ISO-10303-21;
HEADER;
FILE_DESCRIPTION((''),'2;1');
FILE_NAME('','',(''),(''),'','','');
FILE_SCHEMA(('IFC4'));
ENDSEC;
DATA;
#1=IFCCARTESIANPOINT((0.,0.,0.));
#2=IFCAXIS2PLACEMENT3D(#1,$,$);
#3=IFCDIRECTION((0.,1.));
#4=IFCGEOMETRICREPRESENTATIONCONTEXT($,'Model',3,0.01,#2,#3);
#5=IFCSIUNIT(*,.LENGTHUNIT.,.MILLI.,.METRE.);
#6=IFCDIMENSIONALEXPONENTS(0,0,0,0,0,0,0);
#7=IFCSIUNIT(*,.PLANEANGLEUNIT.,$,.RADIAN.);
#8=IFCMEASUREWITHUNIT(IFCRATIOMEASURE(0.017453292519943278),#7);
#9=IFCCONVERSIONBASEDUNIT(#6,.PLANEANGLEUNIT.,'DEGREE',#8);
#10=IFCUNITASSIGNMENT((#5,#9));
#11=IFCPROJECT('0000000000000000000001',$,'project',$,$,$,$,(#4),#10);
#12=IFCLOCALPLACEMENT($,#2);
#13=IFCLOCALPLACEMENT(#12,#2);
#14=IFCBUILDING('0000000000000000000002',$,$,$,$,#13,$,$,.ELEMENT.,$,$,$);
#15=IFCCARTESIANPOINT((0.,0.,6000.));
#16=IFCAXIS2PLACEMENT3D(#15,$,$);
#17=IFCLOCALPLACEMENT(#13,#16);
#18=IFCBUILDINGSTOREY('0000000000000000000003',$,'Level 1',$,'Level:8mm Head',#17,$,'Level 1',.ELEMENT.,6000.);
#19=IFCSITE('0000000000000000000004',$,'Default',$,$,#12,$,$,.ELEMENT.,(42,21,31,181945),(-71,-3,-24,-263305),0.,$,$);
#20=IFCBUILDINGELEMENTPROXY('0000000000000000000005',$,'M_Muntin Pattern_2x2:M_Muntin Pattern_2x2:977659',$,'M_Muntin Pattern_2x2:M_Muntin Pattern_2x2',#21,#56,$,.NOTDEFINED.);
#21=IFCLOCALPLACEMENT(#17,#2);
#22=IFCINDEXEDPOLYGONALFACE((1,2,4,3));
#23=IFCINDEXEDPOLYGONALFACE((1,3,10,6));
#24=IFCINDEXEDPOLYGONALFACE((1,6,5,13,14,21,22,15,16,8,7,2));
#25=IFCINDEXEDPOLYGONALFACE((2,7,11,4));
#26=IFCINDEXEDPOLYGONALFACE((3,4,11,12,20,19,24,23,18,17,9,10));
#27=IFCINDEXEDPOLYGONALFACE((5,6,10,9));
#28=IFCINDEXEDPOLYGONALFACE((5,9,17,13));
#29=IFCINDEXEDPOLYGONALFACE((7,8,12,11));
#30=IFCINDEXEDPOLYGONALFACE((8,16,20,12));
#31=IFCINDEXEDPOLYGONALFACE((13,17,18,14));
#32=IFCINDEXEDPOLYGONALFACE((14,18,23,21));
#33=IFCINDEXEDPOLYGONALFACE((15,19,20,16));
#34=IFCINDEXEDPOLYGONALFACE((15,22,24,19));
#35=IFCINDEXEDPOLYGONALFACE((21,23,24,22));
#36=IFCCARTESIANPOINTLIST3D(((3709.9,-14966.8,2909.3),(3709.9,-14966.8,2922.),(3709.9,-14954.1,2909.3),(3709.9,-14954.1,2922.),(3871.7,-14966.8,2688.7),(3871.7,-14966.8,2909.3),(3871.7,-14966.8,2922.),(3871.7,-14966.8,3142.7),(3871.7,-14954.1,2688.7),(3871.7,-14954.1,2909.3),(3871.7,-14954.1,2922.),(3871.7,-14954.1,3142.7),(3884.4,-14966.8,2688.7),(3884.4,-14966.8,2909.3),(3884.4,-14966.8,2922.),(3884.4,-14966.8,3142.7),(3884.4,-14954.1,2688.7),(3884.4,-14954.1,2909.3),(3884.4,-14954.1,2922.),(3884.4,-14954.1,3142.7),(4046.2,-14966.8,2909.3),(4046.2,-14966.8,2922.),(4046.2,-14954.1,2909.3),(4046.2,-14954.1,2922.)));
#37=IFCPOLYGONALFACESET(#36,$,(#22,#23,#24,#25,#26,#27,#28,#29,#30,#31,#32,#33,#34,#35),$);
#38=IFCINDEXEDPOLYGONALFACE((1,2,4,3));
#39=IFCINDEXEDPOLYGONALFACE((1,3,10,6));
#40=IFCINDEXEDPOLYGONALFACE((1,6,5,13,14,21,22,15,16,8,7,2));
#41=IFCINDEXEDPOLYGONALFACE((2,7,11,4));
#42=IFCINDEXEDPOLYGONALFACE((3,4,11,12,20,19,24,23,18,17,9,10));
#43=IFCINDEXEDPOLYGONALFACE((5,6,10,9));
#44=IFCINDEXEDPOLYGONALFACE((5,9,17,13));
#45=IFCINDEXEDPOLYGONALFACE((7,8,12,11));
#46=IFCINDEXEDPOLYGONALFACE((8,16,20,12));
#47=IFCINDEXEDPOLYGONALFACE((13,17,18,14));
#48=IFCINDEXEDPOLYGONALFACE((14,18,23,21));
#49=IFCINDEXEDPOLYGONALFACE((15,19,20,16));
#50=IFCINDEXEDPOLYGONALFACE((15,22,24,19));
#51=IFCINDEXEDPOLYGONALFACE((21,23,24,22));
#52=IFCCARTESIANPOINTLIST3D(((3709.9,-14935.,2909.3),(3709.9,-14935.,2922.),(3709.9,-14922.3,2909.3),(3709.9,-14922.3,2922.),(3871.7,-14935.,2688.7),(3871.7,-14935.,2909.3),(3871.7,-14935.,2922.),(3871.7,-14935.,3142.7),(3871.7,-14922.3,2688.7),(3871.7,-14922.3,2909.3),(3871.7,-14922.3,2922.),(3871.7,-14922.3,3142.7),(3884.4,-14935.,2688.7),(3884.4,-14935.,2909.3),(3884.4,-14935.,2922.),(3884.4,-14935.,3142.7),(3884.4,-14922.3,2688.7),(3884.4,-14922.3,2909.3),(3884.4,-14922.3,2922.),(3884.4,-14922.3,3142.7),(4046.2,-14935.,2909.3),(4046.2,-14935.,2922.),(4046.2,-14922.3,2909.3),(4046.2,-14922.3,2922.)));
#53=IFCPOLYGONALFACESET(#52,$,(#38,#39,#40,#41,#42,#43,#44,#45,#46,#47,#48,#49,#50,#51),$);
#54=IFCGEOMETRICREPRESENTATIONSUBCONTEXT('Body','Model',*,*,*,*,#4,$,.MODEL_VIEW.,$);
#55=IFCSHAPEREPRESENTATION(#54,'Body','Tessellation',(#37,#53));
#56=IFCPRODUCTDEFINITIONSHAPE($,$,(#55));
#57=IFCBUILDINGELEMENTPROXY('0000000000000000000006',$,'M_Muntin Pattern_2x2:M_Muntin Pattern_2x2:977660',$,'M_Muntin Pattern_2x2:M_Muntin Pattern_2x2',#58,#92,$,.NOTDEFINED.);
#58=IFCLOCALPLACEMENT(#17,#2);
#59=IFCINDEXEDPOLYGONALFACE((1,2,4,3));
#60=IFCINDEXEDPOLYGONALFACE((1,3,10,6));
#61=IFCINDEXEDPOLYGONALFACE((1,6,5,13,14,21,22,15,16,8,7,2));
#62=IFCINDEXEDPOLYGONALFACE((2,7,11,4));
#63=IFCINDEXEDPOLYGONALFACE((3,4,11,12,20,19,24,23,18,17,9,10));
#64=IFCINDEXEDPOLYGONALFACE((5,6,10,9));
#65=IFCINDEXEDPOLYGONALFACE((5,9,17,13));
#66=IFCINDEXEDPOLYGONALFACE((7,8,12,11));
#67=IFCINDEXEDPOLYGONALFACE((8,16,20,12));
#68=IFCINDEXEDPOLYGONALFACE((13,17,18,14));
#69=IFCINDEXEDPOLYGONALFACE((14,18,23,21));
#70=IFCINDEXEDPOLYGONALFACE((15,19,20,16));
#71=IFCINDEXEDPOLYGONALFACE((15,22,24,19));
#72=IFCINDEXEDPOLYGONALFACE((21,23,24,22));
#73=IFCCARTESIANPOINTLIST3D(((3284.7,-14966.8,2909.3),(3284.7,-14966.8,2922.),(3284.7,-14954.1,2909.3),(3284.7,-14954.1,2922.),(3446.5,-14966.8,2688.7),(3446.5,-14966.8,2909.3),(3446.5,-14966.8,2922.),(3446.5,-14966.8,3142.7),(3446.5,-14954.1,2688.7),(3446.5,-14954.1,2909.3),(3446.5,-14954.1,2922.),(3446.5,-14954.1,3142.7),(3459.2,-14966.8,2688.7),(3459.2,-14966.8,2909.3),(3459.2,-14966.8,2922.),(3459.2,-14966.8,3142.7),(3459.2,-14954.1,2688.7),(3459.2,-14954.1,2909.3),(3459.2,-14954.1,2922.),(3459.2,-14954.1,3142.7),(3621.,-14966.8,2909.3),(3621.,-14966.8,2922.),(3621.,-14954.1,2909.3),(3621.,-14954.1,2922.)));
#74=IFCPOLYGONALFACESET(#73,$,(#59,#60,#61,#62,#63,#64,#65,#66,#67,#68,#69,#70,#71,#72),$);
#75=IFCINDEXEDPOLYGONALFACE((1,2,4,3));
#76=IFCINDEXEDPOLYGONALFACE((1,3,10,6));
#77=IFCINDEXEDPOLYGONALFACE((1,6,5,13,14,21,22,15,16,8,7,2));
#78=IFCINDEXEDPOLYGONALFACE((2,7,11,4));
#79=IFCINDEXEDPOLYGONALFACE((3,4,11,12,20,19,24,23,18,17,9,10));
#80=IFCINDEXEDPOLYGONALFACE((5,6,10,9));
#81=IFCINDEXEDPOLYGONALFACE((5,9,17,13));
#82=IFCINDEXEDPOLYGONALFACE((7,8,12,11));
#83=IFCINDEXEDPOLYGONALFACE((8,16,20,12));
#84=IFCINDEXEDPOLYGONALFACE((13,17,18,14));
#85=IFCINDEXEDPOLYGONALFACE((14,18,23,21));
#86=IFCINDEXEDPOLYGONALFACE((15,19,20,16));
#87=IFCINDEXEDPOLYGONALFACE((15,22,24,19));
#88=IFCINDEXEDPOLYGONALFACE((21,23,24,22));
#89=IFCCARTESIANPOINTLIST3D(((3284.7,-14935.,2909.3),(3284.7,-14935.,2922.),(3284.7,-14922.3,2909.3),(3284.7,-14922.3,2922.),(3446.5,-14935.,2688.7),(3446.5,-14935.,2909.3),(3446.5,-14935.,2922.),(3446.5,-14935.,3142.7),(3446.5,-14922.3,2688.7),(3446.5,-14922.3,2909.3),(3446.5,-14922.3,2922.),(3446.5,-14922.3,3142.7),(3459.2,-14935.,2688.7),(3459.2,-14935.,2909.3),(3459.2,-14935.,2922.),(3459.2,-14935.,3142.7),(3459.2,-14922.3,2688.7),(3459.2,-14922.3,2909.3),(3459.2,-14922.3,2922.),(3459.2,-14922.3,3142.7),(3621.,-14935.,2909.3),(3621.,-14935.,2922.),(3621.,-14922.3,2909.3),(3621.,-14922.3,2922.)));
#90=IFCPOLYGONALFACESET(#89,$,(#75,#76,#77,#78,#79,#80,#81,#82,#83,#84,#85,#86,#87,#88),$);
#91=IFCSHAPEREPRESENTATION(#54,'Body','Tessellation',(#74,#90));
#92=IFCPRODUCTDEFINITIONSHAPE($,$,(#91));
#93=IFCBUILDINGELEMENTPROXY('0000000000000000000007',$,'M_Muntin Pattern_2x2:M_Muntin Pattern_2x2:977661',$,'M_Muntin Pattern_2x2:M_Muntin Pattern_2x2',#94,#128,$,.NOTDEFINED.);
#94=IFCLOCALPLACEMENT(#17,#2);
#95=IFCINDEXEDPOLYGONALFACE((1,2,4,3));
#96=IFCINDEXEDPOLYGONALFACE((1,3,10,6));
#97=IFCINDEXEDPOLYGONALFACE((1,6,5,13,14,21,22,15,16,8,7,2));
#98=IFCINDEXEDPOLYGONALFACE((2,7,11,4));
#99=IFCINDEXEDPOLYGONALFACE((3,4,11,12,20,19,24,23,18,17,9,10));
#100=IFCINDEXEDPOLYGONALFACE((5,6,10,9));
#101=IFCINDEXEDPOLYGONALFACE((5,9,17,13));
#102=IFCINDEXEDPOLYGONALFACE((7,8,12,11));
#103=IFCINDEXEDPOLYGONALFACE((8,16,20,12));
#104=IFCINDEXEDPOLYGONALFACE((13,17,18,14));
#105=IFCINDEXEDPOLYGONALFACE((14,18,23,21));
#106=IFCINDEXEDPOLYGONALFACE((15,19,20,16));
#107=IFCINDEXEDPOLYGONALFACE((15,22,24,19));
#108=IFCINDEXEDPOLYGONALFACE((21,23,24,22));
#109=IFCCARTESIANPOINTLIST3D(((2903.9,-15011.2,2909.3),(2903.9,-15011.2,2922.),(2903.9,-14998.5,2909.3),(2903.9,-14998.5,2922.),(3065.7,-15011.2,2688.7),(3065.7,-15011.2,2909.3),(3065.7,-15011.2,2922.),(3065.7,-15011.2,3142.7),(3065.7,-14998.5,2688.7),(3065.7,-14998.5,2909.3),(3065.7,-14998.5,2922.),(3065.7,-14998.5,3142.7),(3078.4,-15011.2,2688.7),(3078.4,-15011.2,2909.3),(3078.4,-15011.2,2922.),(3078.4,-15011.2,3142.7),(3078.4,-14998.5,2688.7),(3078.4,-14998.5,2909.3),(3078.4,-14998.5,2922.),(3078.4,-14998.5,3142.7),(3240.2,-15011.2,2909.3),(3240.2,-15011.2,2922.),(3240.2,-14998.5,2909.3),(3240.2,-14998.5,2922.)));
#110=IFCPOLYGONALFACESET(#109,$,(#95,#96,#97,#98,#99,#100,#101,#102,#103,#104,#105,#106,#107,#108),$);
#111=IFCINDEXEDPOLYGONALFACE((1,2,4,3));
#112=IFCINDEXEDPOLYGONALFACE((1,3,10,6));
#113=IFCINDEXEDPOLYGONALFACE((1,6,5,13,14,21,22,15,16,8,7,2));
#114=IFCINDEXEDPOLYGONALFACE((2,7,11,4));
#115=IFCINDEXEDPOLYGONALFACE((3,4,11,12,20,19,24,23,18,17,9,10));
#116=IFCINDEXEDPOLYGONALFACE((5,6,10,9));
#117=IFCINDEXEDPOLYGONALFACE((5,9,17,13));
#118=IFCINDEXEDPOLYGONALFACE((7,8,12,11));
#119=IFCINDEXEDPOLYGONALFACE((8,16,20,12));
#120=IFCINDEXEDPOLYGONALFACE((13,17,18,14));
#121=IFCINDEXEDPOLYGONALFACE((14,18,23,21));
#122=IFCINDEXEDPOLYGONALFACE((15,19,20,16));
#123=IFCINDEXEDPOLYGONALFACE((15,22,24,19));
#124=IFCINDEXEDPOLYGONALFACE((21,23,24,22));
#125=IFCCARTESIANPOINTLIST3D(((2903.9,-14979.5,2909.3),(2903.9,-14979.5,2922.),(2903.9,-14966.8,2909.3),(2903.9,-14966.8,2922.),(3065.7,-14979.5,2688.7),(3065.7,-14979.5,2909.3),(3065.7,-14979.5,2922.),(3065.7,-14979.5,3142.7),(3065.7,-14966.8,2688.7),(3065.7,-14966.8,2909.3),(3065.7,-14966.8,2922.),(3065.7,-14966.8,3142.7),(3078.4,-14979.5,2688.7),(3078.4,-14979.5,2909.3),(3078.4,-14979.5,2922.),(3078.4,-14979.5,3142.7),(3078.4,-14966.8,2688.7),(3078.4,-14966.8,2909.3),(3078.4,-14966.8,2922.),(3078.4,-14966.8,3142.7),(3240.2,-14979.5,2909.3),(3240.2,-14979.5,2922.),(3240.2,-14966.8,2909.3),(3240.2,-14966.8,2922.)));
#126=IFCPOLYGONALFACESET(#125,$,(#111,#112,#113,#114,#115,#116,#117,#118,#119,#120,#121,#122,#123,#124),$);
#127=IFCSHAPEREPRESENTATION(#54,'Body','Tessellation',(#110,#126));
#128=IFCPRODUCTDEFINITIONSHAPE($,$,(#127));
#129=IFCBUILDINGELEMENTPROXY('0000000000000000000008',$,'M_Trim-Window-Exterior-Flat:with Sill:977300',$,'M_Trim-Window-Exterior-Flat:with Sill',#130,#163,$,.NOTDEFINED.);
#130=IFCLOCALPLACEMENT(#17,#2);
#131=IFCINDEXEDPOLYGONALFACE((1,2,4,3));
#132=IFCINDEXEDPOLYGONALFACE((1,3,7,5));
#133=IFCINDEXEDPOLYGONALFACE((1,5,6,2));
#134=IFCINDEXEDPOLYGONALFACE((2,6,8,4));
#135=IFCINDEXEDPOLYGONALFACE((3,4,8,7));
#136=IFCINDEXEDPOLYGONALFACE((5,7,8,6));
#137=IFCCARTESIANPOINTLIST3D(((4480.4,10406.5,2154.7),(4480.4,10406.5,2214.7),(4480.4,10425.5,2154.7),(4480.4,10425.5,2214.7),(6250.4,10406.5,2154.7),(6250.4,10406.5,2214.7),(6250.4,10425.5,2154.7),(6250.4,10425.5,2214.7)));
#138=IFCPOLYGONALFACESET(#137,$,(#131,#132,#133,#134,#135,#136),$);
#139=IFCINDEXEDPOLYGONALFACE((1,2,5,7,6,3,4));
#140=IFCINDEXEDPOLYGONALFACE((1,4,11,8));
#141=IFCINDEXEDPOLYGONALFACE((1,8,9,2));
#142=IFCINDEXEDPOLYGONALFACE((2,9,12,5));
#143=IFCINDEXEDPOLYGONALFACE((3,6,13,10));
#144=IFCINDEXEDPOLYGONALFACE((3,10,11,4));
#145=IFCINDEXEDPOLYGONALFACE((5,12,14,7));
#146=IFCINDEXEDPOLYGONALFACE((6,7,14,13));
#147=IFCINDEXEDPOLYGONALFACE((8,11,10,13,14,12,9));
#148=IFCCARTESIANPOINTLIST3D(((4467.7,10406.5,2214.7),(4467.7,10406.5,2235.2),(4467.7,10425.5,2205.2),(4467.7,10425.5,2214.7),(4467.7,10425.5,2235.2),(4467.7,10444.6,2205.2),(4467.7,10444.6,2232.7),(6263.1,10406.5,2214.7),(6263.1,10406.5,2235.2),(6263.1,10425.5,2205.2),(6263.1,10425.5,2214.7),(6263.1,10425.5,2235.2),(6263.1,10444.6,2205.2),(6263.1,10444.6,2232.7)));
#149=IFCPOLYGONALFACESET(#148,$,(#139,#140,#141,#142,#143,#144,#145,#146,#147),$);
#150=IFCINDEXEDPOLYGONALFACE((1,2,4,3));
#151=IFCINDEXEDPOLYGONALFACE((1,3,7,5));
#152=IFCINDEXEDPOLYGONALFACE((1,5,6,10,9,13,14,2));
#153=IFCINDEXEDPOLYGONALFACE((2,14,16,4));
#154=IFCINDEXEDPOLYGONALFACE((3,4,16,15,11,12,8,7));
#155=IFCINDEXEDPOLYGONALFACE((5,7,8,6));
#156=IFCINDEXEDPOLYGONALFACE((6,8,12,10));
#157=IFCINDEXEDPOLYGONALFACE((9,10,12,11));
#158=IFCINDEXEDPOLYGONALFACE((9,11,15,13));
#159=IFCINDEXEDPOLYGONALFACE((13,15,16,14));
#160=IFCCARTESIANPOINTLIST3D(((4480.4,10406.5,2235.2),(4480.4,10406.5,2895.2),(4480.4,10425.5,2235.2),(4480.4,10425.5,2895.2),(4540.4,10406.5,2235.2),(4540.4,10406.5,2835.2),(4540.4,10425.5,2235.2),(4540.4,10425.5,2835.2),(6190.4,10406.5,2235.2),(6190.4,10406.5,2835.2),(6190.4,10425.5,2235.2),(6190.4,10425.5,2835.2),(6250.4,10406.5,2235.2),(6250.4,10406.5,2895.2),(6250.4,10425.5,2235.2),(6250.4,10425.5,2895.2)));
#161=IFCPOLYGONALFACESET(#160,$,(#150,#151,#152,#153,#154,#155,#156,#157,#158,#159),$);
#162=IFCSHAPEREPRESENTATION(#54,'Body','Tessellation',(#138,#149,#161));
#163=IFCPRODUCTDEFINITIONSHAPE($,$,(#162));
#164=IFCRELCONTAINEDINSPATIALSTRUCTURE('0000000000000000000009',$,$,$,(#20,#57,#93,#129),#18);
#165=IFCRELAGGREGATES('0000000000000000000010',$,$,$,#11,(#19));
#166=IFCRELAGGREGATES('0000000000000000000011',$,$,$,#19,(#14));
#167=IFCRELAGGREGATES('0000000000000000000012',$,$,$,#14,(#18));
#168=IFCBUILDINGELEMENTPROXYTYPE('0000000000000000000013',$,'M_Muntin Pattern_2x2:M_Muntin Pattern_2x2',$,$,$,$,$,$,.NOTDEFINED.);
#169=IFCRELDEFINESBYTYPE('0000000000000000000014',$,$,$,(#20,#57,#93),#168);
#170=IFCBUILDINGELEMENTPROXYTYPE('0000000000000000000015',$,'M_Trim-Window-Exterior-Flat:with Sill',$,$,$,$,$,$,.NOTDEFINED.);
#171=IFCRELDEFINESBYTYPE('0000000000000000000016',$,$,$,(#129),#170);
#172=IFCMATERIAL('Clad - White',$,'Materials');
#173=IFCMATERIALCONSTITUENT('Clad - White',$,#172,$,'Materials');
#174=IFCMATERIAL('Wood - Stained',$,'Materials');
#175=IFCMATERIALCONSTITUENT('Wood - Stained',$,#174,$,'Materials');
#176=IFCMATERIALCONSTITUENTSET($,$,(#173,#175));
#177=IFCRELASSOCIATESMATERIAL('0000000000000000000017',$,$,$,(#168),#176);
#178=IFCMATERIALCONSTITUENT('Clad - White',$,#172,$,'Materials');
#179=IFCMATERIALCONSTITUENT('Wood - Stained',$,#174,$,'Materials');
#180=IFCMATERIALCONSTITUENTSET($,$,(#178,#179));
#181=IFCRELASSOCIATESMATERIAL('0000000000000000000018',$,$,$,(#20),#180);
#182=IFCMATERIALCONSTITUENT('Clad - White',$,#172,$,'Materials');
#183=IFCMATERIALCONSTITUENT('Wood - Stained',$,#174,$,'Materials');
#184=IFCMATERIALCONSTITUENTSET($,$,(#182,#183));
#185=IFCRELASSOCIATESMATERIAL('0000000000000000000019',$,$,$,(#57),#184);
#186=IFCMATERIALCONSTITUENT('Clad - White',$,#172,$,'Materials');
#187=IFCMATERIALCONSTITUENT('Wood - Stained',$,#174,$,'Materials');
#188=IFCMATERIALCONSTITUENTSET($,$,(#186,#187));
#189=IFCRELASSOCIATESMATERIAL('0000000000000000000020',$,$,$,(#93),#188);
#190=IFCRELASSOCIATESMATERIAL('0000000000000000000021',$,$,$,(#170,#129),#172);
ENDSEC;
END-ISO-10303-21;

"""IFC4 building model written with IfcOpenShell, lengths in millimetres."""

from ifc_helpers import new_model, entity, si_unit, converted_unit, direction, frame, frame_2d, origin, place, context, subcontext, project, spatial, polyline, rectangle, outline, extrude, source, transform, mapped, material, constituent, constituent_set, type_object, type_shapes, element, save


model = new_model("IFC4")

# Units and contexts
model_context = context("Model", 3, precision=0.01, world=origin(), true_north=direction((0.0, 1.0)))
body_context = subcontext(model_context, "Body", "Model", "MODEL_VIEW")
ifc_project = project(units=[si_unit("LENGTHUNIT", "METRE", prefix="MILLI"), converted_unit("PLANEANGLEUNIT", "DEGREE", entity("IfcRatioMeasure", 0.017453292519943278), si_unit("PLANEANGLEUNIT", "RADIAN"), dimensions=[0, 0, 0, 0, 0, 0, 0])], contexts=[model_context])

# Site, building, storey
site_placement = place(None, origin())
site = spatial("IfcSite", under=ifc_project, at=site_placement, Name="Default", CompositionType="ELEMENT", RefLatitude=(42, 21, 31, 181945), RefLongitude=(-71, -3, -24, -263305), RefElevation=0.0)
building_placement = place(site_placement, origin())
building = spatial("IfcBuilding", under=site, at=building_placement, CompositionType="ELEMENT")
storey_placement = place(building_placement, frame((0.0, 0.0, 6000.0)))
storey = spatial("IfcBuildingStorey", under=building, at=storey_placement, Name="Level 1", ObjectType="Level:8mm Head", LongName="Level 1", CompositionType="ELEMENT", Elevation=6000.0)

# Building element proxies
ifc_material_1 = material(Name="Clad - White", Category="Materials")
ifc_material_2 = material(Name="Wood - Stained", Category="Materials")
ifc_constituent_1 = constituent(ifc_material_1, Name="Clad - White", Category="Materials")
ifc_constituent_2 = constituent(ifc_material_2, Name="Wood - Stained", Category="Materials")
ifc_constituent_set_1 = constituent_set(constituents=[ifc_constituent_1, ifc_constituent_2])
building_element_proxy_type_1 = type_object("IfcBuildingElementProxyType", Name="M_Muntin Pattern_2x2:M_Muntin Pattern_2x2", PredefinedType="NOTDEFINED", material=ifc_constituent_set_1)
shared_shape_1 = source(origin(), body_context, "Body", "SweptSolid", [
    extrude(outline(polyline([(6.4, -6.4), (227.0, -6.4), (227.0, 6.3), (6.4, 6.3), (6.4, 168.2), (-6.3, 168.2), (-6.3, 6.3), (-227.0, 6.3), (-227.0, -6.4), (-6.3, -6.4), (-6.3, -168.1), (6.4, -168.1), (6.4, -6.4)])), frame((0.0, 9.5, 227.0), z_axis=(0.0, 1.0, 0.0), x_axis=(0.0, 0.0, 1.0)), (0.0, 0.0, 1.0), 12.7),
    extrude(outline(polyline([(6.4, -6.4), (227.0, -6.4), (227.0, 6.3), (6.4, 6.3), (6.4, 168.2), (-6.3, 168.2), (-6.3, 6.3), (-227.0, 6.3), (-227.0, -6.4), (-6.3, -6.4), (-6.3, -168.1), (6.4, -168.1), (6.4, -6.4)])), frame((0.0, -22.2, 227.0), z_axis=(0.0, 1.0, 0.0), x_axis=(0.0, 0.0, 1.0)), (0.0, 0.0, 1.0), 12.7),
])
type_shapes(building_element_proxy_type_1, [shared_shape_1])
ifc_constituent_3 = constituent(ifc_material_1, Name="Clad - White", Category="Materials")
ifc_constituent_4 = constituent(ifc_material_2, Name="Wood - Stained", Category="Materials")
ifc_constituent_set_2 = constituent_set(constituents=[ifc_constituent_3, ifc_constituent_4])
proxy_1_placement = place(storey_placement, frame((3878.0, -14944.6, 2688.7), z_axis=(0.0, 0.0, 1.0), x_axis=(-1.0, 0.0, 0.0)))
element("IfcBuildingElementProxy", 1, at=proxy_1_placement, inside=storey, type_object=building_element_proxy_type_1, material=ifc_constituent_set_2, Name="M_Muntin Pattern_2x2:M_Muntin Pattern_2x2:977659", ObjectType="M_Muntin Pattern_2x2:M_Muntin Pattern_2x2", PredefinedType="NOTDEFINED", context=body_context, shape_type="MappedRepresentation", body=[
    mapped(shared_shape_1, transform((0.0, 0.0, 0.0), scale=1.0)),
])
ifc_constituent_5 = constituent(ifc_material_1, Name="Clad - White", Category="Materials")
ifc_constituent_6 = constituent(ifc_material_2, Name="Wood - Stained", Category="Materials")
ifc_constituent_set_3 = constituent_set(constituents=[ifc_constituent_5, ifc_constituent_6])
proxy_2_placement = place(storey_placement, frame((3452.8, -14944.6, 2688.7), z_axis=(0.0, 0.0, 1.0), x_axis=(-1.0, 0.0, 0.0)))
element("IfcBuildingElementProxy", 2, at=proxy_2_placement, inside=storey, type_object=building_element_proxy_type_1, material=ifc_constituent_set_3, Name="M_Muntin Pattern_2x2:M_Muntin Pattern_2x2:977660", ObjectType="M_Muntin Pattern_2x2:M_Muntin Pattern_2x2", PredefinedType="NOTDEFINED", context=body_context, shape_type="MappedRepresentation", body=[
    mapped(shared_shape_1, transform((0.0, 0.0, 0.0), scale=1.0)),
])
ifc_constituent_7 = constituent(ifc_material_1, Name="Clad - White", Category="Materials")
ifc_constituent_8 = constituent(ifc_material_2, Name="Wood - Stained", Category="Materials")
ifc_constituent_set_4 = constituent_set(constituents=[ifc_constituent_7, ifc_constituent_8])
proxy_3_placement = place(storey_placement, frame((3072.1, -14989.0, 2688.7), z_axis=(0.0, 0.0, 1.0), x_axis=(-1.0, 0.0, 0.0)))
element("IfcBuildingElementProxy", 3, at=proxy_3_placement, inside=storey, type_object=building_element_proxy_type_1, material=ifc_constituent_set_4, Name="M_Muntin Pattern_2x2:M_Muntin Pattern_2x2:977661", ObjectType="M_Muntin Pattern_2x2:M_Muntin Pattern_2x2", PredefinedType="NOTDEFINED", context=body_context, shape_type="MappedRepresentation", body=[
    mapped(shared_shape_1, transform((0.0, 0.0, 0.0), scale=1.0)),
])
building_element_proxy_type_2 = type_object("IfcBuildingElementProxyType", Name="M_Trim-Window-Exterior-Flat:with Sill", PredefinedType="NOTDEFINED", material=ifc_material_1)
shared_shape_2 = source(origin(), body_context, "Body", "SweptSolid", [
    extrude(rectangle(XDim=1770.0, YDim=60.0, at=frame_2d((0.0, 0.0), x_axis=(1.0, 0.0))), frame((0.0, -650.4, 0.0), z_axis=(0.0, 0.0, 1.0), x_axis=(-1.0, 0.0, 0.0)), (0.0, 0.0, 1.0), 19.0),
    extrude(outline(polyline([(-19.0, -15.2), (0.0, -15.2), (0.0, -5.7), (19.0, -5.7), (19.0, 14.8), (0.0, 14.8), (-19.0, 12.3), (-19.0, -15.2)])), frame((-897.7, -614.8, 19.0), z_axis=(1.0, 0.0, 0.0), x_axis=(0.0, 0.0, -1.0)), (0.0, 0.0, 1.0), 1795.4),
    extrude(outline(polyline([(-345.0, -885.0), (315.0, -885.0), (315.0, -825.0), (-285.0, -825.0), (-285.0, 825.0), (315.0, 825.0), (315.0, 885.0), (-345.0, 885.0), (-345.0, -885.0)])), frame((0.0, -285.0, 0.0), z_axis=(0.0, 0.0, 1.0), x_axis=(0.0, -1.0, 0.0)), (0.0, 0.0, 1.0), 19.0),
])
type_shapes(building_element_proxy_type_2, [shared_shape_2])
for number, where, z_axis, x_axis, name in (
    (4, (5365.4, 10406.5, 2835.2), (0.0, 1.0, 0.0), (-1.0, 0.0, 0.0), "M_Trim-Window-Exterior-Flat:with Sill:977300"),
):
    element("IfcBuildingElementProxy", number, at=place(storey_placement, frame(where, z_axis=z_axis, x_axis=x_axis)), inside=storey, type_object=building_element_proxy_type_2, material=ifc_material_1, Name=name, ObjectType="M_Trim-Window-Exterior-Flat:with Sill", PredefinedType="NOTDEFINED", context=body_context, shape_type="MappedRepresentation", body=[
        mapped(shared_shape_2, transform((0.0, 0.0, 0.0), scale=1.0)),
    ])

save(model, "model.ifc")
